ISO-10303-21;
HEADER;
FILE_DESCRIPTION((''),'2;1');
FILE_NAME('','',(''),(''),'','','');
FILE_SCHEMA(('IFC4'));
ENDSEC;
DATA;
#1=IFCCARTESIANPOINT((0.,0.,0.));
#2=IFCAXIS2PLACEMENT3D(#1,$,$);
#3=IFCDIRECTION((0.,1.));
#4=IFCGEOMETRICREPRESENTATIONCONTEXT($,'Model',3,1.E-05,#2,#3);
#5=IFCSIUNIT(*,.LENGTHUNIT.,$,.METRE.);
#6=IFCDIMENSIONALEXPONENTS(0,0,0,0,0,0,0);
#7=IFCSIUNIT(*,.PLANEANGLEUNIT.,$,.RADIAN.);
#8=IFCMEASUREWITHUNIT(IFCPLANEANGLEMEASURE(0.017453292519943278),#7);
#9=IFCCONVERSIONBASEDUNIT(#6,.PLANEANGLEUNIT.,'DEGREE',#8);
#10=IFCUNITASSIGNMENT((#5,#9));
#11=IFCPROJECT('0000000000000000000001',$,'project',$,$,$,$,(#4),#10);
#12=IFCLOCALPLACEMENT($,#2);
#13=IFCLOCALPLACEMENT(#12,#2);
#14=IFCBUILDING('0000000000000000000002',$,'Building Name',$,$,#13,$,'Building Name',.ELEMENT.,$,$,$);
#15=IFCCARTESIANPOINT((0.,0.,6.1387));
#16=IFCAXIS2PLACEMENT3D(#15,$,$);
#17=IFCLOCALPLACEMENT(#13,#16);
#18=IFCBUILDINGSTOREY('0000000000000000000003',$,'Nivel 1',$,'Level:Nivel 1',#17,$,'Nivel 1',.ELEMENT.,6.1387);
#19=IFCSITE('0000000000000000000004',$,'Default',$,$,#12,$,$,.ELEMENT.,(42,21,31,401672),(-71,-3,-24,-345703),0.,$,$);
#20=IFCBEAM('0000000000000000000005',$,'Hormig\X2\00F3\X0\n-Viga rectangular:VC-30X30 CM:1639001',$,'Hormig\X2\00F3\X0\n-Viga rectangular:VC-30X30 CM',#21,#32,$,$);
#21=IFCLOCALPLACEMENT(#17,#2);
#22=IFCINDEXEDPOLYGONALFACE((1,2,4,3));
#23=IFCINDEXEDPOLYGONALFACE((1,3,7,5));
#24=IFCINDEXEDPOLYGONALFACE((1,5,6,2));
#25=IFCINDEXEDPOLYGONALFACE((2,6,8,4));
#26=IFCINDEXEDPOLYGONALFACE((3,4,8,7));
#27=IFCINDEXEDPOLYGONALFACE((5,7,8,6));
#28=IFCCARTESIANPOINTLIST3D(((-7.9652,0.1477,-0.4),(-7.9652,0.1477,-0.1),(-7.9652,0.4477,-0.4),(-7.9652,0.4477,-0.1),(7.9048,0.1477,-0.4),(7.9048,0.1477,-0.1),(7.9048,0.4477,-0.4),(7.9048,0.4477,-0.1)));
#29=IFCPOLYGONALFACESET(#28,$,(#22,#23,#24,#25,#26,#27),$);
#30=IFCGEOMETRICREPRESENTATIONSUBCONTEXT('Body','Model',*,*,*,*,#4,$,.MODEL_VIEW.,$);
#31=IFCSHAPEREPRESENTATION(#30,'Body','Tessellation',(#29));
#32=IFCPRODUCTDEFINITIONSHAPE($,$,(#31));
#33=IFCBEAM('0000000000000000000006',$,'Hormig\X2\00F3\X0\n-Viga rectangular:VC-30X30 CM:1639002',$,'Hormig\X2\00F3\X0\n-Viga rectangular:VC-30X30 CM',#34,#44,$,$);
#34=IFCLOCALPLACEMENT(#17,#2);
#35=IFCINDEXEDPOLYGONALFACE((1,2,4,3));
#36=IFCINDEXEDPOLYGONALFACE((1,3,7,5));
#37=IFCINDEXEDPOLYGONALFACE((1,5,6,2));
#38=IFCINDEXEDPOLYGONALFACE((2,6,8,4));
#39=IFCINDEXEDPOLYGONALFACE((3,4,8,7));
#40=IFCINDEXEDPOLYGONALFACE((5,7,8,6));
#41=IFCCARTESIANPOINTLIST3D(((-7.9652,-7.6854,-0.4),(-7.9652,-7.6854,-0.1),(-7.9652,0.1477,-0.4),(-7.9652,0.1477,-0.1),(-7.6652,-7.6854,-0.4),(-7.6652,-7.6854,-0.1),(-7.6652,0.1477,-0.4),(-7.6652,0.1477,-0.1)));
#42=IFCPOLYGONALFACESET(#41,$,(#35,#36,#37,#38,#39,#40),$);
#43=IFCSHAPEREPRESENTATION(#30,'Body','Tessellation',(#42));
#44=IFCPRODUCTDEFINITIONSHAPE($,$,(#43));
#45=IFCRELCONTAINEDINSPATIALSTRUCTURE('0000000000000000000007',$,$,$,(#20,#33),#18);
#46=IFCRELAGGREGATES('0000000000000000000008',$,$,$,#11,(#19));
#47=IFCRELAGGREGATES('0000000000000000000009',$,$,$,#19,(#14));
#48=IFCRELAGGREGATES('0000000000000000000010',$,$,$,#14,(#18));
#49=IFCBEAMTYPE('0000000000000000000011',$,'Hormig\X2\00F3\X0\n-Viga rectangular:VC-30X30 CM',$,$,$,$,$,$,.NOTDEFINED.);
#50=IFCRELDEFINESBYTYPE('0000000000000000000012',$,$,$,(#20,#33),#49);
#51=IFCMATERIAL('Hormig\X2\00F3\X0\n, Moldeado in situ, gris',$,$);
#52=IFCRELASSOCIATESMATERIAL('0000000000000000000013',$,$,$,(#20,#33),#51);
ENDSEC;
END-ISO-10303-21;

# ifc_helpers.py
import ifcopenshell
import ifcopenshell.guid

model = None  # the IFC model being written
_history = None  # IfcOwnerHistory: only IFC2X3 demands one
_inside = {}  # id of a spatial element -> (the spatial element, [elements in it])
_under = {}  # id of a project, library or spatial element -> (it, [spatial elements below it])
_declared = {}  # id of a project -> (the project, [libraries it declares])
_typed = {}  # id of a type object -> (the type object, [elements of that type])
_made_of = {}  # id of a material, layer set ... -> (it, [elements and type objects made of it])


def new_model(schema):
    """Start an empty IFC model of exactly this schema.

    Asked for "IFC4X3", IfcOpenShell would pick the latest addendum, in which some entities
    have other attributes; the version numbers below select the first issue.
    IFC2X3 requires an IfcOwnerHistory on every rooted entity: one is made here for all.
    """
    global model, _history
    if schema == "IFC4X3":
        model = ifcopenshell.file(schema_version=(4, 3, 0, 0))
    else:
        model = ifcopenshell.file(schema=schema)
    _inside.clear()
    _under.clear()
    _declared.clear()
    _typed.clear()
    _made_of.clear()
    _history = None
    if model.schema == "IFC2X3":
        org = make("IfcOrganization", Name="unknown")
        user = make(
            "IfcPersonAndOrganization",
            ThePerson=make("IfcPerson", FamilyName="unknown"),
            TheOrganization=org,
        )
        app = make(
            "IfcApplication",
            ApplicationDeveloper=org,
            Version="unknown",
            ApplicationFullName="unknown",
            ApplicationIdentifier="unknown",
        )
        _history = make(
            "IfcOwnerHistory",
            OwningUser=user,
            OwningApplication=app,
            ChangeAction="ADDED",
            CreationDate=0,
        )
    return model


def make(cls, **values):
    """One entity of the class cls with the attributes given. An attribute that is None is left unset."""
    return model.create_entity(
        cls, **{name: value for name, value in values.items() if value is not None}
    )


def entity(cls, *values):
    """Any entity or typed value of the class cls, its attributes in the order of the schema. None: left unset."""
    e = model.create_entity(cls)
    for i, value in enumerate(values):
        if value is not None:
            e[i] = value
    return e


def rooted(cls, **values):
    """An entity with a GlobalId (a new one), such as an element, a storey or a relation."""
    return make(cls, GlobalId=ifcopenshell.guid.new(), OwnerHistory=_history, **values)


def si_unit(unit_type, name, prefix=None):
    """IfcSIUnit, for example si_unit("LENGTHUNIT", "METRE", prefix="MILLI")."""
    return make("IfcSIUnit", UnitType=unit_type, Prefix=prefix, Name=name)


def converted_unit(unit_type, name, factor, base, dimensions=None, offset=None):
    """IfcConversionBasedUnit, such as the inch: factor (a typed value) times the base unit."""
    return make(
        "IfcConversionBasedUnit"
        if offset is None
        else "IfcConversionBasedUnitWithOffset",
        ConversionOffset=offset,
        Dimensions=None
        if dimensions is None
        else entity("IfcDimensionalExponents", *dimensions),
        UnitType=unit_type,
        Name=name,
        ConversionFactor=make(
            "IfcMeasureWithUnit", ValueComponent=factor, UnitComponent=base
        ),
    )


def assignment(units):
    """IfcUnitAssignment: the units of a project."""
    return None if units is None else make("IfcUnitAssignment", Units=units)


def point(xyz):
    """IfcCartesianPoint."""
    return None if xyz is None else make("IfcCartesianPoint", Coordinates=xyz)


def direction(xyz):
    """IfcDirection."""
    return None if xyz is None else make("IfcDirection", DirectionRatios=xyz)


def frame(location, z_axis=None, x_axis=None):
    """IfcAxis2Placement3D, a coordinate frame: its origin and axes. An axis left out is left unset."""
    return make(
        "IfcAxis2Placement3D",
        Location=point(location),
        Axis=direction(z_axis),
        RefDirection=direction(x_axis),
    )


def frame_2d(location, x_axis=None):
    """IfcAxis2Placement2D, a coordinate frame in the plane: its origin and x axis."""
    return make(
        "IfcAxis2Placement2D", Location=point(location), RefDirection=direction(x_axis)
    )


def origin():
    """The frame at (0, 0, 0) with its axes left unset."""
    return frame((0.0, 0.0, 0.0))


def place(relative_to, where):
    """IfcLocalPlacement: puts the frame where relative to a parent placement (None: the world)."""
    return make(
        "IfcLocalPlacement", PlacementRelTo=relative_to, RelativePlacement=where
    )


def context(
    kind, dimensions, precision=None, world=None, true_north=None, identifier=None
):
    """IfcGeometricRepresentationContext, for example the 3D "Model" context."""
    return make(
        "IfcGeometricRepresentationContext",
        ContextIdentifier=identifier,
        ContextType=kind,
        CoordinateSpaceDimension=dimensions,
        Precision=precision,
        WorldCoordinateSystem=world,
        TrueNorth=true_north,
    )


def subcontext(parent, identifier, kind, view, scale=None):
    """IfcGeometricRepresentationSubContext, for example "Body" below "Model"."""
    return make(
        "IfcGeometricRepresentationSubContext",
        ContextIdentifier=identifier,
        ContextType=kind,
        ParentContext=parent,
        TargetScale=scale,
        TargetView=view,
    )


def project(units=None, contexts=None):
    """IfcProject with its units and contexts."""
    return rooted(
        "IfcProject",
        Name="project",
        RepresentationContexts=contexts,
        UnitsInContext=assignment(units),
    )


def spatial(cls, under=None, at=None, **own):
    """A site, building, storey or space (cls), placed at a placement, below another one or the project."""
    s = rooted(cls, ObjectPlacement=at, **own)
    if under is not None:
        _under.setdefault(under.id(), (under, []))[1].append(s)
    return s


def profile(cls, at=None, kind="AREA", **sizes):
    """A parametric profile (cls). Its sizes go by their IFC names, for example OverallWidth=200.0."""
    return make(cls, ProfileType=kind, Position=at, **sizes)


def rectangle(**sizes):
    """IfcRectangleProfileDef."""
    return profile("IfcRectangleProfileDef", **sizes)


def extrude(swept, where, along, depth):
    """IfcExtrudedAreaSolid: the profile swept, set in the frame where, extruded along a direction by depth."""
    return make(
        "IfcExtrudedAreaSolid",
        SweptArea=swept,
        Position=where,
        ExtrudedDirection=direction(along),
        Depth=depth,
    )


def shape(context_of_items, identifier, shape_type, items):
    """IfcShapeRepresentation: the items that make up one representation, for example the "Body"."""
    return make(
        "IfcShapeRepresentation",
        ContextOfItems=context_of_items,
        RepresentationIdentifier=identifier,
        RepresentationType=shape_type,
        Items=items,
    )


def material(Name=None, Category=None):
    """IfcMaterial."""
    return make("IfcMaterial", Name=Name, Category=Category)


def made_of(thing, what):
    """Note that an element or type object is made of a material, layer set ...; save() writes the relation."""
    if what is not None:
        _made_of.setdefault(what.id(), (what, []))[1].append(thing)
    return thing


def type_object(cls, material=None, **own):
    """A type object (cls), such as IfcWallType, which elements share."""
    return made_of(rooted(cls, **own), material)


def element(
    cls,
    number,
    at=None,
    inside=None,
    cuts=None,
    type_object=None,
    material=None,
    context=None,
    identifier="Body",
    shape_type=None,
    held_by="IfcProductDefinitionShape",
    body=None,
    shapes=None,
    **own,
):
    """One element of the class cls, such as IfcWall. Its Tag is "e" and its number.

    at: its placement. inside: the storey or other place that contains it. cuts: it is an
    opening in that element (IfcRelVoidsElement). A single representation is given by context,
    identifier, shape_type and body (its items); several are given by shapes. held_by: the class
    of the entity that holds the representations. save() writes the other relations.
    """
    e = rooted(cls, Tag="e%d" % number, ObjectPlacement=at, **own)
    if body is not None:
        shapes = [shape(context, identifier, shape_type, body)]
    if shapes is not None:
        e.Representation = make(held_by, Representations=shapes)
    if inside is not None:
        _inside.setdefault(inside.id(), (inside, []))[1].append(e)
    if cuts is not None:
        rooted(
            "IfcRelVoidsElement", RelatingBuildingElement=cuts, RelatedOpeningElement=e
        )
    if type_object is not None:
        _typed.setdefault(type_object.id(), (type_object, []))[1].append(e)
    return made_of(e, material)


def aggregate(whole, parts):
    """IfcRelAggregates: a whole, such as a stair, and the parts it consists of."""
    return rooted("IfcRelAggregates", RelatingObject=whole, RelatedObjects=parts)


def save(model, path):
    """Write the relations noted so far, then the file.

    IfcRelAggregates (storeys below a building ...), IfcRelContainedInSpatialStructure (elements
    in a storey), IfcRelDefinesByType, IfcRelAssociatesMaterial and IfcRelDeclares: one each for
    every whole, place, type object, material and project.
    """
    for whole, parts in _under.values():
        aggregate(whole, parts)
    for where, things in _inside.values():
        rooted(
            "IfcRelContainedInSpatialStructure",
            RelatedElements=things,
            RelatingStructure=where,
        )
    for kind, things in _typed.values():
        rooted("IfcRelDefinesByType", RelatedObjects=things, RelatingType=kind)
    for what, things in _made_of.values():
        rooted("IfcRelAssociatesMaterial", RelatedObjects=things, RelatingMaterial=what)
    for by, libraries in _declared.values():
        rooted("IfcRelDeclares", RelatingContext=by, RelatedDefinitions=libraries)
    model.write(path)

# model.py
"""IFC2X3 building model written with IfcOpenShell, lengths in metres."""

from ifc_helpers import new_model, entity, si_unit, converted_unit, direction, frame, frame_2d, origin, place, context, subcontext, project, spatial, rectangle, extrude, material, type_object, element, save


model = new_model("IFC2X3")

# Units and contexts
model_context = context("Model", 3, precision=1e-05, world=origin(), true_north=direction((0.0, 1.0)))
body_context = subcontext(model_context, "Body", "Model", "MODEL_VIEW")
ifc_project = project(units=[si_unit("LENGTHUNIT", "METRE"), converted_unit("PLANEANGLEUNIT", "DEGREE", entity("IfcPlaneAngleMeasure", 0.017453292519943278), si_unit("PLANEANGLEUNIT", "RADIAN"), dimensions=[0, 0, 0, 0, 0, 0, 0])], contexts=[model_context])

# Site, building, storey
site_placement = place(None, origin())
site = spatial("IfcSite", under=ifc_project, at=site_placement, Name="Default", CompositionType="ELEMENT", RefLatitude=(42, 21, 31, 401672), RefLongitude=(-71, -3, -24, -345703), RefElevation=0.0)
building_placement = place(site_placement, origin())
building = spatial("IfcBuilding", under=site, at=building_placement, Name="Building Name", LongName="Building Name", CompositionType="ELEMENT")
storey_placement = place(building_placement, frame((0.0, 0.0, 6.1387)))
storey = spatial("IfcBuildingStorey", under=building, at=storey_placement, Name="Nivel 1", ObjectType="Level:Nivel 1", LongName="Nivel 1", CompositionType="ELEMENT", Elevation=6.1387)

# Beams
ifc_material = material(Name="Hormigón, Moldeado in situ, gris")
beam_type = type_object("IfcBeamType", Name="Hormigón-Viga rectangular:VC-30X30 CM", PredefinedType="NOTDEFINED")
beam_1_placement = place(storey_placement, frame((-7.8152, 0.2977, -0.1)))
element("IfcBeam", 1, at=beam_1_placement, inside=storey, type_object=beam_type, material=ifc_material, Name="Hormigón-Viga rectangular:VC-30X30 CM:1639001", ObjectType="Hormigón-Viga rectangular:VC-30X30 CM", context=body_context, shape_type="SweptSolid", body=[
    extrude(rectangle(XDim=0.3, YDim=0.3, at=frame_2d((0.0, 0.0), x_axis=(1.0, 0.0))), frame((-0.15, 0.0, -0.15), z_axis=(1.0, 0.0, 0.0), x_axis=(0.0, 0.0, -1.0)), (0.0, 0.0, 1.0), 15.87),
])
beam_2_placement = place(storey_placement, frame((-7.8152, 0.2977, -0.1), z_axis=(0.0, 0.0, 1.0), x_axis=(0.0, -1.0, 0.0)))
element("IfcBeam", 2, at=beam_2_placement, inside=storey, type_object=beam_type, material=ifc_material, Name="Hormigón-Viga rectangular:VC-30X30 CM:1639002", ObjectType="Hormigón-Viga rectangular:VC-30X30 CM", context=body_context, shape_type="SweptSolid", body=[
    extrude(rectangle(XDim=0.3, YDim=0.3, at=frame_2d((0.0, 0.0), x_axis=(1.0, 0.0))), frame((0.15, 0.0, -0.15), z_axis=(1.0, 0.0, 0.0), x_axis=(0.0, 0.0, -1.0)), (0.0, 0.0, 1.0), 7.8332),
])

save(model, "model.ifc")
